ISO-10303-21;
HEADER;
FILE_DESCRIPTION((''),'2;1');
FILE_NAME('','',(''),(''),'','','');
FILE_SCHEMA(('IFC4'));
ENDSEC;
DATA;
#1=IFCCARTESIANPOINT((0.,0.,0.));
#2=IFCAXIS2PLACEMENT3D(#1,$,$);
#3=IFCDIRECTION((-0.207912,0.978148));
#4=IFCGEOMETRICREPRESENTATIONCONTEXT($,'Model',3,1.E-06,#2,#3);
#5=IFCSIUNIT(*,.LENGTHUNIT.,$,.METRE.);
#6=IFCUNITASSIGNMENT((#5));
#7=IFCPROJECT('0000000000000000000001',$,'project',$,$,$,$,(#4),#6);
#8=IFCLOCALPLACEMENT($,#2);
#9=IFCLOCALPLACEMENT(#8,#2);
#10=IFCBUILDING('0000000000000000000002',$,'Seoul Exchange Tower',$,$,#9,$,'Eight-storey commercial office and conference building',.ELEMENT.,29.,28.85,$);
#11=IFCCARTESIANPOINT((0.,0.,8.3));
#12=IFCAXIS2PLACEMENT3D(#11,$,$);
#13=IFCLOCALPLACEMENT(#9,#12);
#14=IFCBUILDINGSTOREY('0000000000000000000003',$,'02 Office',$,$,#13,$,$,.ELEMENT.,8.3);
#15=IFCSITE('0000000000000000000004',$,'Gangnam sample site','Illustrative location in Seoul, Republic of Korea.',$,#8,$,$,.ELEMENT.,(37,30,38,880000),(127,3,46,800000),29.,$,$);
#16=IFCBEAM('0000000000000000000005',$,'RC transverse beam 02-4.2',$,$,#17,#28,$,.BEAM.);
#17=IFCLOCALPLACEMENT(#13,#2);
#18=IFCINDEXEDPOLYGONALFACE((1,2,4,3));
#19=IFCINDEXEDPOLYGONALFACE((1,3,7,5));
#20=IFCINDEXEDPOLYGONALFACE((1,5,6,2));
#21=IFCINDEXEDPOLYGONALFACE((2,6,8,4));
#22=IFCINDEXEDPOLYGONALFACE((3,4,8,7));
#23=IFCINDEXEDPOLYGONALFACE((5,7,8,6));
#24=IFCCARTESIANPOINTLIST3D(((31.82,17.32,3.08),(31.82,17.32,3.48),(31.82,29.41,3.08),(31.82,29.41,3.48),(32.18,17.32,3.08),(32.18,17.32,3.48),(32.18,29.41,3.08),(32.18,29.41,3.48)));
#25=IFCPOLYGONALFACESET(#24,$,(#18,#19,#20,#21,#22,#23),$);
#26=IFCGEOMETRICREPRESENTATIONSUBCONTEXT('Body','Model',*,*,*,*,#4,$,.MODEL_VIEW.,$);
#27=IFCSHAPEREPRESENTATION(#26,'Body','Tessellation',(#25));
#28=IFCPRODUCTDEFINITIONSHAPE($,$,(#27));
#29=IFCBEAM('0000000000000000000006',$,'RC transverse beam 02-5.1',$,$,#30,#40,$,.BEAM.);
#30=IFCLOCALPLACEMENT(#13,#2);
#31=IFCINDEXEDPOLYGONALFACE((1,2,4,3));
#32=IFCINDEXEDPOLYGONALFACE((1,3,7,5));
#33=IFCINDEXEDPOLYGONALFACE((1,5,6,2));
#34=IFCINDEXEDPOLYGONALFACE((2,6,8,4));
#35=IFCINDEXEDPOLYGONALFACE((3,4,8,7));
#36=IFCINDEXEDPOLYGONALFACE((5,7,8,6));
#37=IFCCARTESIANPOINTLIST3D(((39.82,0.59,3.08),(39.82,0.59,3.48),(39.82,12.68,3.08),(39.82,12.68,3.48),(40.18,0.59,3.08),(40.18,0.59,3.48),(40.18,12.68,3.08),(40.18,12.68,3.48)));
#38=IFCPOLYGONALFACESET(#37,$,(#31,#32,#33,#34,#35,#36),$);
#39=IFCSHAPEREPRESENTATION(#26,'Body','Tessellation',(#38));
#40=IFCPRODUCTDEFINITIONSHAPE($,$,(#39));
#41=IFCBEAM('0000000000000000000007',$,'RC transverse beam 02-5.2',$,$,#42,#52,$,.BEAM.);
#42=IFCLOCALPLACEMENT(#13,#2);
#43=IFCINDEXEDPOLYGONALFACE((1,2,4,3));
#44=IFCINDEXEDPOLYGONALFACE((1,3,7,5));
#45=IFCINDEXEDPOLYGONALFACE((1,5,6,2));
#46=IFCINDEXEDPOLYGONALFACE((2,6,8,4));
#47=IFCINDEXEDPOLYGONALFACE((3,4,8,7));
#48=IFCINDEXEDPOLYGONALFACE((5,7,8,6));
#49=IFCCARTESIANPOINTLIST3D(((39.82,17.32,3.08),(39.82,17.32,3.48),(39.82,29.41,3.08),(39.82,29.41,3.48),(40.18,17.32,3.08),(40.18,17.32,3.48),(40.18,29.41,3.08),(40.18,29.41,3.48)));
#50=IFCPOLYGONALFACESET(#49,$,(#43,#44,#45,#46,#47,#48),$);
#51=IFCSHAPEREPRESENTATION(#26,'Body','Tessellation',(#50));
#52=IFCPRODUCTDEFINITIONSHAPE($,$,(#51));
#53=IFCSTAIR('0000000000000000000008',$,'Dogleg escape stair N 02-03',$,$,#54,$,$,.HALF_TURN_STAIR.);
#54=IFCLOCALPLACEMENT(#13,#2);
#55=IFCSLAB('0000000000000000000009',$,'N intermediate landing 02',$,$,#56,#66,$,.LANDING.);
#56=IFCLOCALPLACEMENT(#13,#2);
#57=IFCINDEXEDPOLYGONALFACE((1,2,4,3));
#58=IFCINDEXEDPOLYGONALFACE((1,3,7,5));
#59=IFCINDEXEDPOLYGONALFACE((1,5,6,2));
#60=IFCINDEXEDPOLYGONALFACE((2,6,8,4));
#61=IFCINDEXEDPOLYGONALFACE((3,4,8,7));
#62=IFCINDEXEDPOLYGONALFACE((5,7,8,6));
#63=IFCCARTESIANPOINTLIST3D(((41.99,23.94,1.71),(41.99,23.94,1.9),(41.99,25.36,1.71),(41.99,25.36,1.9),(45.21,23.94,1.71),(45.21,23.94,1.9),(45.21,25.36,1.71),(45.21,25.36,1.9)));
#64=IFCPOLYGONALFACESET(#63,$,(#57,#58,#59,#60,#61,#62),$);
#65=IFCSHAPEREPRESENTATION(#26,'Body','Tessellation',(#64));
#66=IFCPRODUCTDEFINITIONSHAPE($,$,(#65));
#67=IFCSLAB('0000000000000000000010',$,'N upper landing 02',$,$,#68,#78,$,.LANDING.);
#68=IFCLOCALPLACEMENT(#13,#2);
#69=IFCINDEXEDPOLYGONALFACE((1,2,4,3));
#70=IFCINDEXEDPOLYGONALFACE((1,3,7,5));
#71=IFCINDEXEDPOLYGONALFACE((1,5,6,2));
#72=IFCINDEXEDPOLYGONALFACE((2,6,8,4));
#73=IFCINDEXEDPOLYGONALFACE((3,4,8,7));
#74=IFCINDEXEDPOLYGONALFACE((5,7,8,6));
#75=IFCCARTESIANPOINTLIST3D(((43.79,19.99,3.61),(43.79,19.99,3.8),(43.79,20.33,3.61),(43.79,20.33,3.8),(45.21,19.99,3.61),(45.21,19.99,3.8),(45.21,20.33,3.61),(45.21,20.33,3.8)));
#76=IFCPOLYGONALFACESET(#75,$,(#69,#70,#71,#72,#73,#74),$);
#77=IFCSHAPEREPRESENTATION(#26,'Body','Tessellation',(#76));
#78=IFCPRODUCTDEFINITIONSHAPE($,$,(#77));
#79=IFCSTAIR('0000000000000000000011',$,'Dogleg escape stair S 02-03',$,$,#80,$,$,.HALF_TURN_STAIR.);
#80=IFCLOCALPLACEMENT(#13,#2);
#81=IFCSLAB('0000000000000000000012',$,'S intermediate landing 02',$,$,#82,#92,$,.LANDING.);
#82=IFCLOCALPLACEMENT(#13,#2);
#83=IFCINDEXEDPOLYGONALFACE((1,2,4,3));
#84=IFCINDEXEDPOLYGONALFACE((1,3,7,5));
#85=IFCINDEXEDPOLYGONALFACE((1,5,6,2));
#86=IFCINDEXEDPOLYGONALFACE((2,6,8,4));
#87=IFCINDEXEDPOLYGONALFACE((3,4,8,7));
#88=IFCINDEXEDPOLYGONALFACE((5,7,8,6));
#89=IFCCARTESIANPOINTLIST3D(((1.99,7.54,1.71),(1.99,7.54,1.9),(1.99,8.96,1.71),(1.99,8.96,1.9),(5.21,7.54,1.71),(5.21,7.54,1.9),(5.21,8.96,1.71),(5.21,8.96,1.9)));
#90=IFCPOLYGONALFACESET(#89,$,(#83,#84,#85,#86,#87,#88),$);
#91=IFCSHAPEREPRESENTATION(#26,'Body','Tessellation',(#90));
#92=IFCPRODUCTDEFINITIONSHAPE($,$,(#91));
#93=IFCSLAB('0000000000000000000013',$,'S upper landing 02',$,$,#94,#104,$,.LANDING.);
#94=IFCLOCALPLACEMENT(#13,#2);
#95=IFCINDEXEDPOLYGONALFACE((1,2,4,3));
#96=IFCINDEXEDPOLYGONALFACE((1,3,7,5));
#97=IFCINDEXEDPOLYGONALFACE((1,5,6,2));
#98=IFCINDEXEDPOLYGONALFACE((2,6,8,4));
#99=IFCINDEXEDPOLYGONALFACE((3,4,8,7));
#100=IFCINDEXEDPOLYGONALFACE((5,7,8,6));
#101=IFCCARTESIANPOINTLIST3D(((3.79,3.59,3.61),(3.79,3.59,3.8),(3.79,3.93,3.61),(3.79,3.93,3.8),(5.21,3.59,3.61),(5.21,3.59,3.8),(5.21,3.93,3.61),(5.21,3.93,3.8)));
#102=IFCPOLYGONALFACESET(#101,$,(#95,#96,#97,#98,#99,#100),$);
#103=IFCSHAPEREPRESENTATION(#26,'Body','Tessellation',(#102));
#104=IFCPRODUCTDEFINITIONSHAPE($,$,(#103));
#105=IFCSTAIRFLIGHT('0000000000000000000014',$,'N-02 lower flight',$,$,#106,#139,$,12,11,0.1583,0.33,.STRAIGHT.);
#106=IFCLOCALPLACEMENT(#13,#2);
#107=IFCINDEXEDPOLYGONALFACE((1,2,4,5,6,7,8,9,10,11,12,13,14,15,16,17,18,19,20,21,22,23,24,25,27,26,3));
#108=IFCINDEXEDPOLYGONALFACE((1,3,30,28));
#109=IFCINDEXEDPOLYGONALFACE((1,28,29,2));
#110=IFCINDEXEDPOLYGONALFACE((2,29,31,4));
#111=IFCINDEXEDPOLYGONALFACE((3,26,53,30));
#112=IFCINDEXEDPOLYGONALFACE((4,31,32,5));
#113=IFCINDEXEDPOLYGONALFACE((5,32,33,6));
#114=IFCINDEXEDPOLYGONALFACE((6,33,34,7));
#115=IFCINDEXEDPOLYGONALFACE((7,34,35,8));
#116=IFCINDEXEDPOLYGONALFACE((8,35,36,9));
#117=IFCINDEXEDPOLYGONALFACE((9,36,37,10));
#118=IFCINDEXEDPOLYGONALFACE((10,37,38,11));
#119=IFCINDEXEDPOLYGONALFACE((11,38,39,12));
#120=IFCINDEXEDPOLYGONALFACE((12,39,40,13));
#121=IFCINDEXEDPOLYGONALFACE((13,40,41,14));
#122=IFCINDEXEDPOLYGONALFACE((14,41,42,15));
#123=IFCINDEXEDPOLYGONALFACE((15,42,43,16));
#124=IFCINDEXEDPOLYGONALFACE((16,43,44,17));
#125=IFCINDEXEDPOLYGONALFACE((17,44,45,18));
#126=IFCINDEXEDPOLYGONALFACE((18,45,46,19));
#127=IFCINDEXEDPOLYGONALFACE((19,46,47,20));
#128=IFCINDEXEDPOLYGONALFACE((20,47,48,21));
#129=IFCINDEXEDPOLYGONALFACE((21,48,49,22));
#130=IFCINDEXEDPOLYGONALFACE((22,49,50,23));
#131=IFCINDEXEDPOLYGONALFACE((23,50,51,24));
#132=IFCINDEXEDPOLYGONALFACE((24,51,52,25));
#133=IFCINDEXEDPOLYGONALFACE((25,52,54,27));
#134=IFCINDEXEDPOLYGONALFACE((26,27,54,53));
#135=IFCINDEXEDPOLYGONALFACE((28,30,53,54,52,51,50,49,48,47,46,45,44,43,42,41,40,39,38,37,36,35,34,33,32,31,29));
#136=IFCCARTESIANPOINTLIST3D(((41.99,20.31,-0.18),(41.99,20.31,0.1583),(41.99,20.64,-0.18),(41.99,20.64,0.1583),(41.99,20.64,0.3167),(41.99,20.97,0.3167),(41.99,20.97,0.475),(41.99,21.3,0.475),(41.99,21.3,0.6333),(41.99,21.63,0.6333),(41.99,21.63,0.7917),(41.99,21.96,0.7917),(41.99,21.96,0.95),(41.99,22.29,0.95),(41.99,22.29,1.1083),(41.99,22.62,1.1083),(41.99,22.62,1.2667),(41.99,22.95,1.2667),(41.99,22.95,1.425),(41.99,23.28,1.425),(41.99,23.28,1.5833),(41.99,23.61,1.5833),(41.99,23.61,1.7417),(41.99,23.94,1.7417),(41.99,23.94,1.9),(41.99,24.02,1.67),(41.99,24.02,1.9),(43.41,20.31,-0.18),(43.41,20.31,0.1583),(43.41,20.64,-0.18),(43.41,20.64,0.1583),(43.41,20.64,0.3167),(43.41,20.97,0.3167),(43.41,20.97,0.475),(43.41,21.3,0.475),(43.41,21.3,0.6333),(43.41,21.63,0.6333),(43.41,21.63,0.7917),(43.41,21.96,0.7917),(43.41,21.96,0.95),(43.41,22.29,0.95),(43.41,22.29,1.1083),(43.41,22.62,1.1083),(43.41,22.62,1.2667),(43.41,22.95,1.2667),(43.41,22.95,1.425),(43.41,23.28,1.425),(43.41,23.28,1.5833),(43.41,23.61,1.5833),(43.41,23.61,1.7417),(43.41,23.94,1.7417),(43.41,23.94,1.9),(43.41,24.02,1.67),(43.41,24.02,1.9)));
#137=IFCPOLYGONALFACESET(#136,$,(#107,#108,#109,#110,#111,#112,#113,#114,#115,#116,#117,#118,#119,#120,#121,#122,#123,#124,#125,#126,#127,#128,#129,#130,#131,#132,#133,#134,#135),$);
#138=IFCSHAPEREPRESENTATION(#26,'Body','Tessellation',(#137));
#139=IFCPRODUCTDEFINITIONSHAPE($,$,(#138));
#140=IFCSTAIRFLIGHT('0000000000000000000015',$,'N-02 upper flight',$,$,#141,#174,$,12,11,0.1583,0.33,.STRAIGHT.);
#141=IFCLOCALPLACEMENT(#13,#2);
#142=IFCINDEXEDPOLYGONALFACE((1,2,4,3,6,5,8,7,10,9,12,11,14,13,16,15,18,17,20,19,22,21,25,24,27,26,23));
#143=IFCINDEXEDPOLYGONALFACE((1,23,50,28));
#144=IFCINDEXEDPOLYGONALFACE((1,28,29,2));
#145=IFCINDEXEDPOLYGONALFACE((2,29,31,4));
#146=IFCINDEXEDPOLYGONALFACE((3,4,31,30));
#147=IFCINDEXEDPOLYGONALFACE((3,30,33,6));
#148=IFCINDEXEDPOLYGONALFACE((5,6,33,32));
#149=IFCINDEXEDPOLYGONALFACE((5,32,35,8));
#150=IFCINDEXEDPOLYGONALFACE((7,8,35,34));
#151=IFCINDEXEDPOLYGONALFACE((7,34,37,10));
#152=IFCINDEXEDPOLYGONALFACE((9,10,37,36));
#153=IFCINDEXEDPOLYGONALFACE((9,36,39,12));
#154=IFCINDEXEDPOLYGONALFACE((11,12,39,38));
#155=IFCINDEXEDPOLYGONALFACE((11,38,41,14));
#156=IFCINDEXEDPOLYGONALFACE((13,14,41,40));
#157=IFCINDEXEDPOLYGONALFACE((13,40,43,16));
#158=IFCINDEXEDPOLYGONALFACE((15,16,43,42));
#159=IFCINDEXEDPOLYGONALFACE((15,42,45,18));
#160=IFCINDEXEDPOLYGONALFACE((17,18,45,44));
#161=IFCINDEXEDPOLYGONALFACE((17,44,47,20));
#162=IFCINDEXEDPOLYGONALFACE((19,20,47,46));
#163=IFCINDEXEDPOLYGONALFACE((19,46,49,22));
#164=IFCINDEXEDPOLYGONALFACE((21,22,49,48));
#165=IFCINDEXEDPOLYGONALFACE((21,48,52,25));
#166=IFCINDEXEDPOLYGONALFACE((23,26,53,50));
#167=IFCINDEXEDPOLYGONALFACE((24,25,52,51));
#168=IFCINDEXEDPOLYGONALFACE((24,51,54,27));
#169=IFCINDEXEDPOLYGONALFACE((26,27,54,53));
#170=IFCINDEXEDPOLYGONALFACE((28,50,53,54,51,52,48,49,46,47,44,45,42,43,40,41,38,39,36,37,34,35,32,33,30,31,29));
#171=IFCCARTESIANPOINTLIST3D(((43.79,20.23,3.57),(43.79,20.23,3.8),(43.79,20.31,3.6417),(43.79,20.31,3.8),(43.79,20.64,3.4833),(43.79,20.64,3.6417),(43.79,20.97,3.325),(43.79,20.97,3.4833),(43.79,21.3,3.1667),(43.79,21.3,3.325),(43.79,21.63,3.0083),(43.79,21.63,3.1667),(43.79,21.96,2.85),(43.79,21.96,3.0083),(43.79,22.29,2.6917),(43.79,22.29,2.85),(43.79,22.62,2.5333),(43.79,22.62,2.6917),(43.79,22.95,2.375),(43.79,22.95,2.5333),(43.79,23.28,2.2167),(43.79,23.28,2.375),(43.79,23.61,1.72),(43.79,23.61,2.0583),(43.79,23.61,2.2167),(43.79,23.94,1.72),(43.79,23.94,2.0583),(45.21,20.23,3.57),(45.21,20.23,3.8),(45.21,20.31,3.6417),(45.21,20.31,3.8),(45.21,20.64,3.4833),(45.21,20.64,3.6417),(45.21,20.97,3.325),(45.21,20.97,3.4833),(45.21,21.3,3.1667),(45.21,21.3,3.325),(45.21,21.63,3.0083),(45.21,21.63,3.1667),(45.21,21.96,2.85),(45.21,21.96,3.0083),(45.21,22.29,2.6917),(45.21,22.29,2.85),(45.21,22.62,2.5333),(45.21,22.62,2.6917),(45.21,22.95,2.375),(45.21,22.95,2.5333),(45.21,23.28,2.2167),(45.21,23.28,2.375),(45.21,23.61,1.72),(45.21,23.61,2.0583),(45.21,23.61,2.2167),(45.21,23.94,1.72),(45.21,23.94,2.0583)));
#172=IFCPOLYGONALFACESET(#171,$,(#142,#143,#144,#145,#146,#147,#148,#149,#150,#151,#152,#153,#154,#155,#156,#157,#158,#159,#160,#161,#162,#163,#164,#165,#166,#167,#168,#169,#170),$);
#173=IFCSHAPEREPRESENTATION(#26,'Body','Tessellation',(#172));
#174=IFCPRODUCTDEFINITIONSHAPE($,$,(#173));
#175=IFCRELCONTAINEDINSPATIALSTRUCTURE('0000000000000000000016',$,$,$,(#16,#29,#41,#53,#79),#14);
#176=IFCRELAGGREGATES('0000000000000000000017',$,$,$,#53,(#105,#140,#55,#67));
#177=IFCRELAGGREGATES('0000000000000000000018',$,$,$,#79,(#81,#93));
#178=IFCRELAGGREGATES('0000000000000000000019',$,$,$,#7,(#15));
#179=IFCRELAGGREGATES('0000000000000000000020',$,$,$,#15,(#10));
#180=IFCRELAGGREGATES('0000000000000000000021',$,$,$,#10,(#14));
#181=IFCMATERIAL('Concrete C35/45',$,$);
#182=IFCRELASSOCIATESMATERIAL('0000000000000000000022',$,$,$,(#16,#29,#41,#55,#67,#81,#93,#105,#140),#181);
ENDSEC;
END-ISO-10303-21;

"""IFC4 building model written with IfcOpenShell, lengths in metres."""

from ifc_helpers import new_model, si_unit, direction, frame, frame_2d, origin, place, context, subcontext, project, spatial, polyline, rectangle, outline, extrude, material, element, aggregate, save


model = new_model("IFC4")

# Units and contexts
model_context = context("Model", 3, precision=1e-06, world=origin(), true_north=direction((-0.207912, 0.978148)))
body_context = subcontext(model_context, "Body", "Model", "MODEL_VIEW")
ifc_project = project(units=[si_unit("LENGTHUNIT", "METRE")], contexts=[model_context])

# Site, building, storey
site_placement = place(None, origin())
site = spatial("IfcSite", under=ifc_project, at=site_placement, Name="Gangnam sample site", Description="Illustrative location in Seoul, Republic of Korea.", CompositionType="ELEMENT", RefLatitude=(37, 30, 38, 880000), RefLongitude=(127, 3, 46, 800000), RefElevation=29.0)
building_placement = place(site_placement, origin())
building = spatial("IfcBuilding", under=site, at=building_placement, Name="Seoul Exchange Tower", LongName="Eight-storey commercial office and conference building", CompositionType="ELEMENT", ElevationOfRefHeight=29.0, ElevationOfTerrain=28.85)
storey_placement = place(building_placement, frame((0.0, 0.0, 8.3)))
storey = spatial("IfcBuildingStorey", under=building, at=storey_placement, Name="02 Office", CompositionType="ELEMENT", Elevation=8.3)

# Beams
ifc_material_1 = material(Name="Concrete C35/45")
placement_1 = place(storey_placement, origin())
element("IfcBeam", 1, at=placement_1, inside=storey, material=ifc_material_1, Name="RC transverse beam 02-4.2", PredefinedType="BEAM", context=body_context, shape_type="SweptSolid", body=[
    extrude(rectangle(XDim=0.36, YDim=12.09, at=frame_2d((0.18, 6.045))), frame((31.82, 17.32, 3.08)), (0.0, 0.0, 1.0), 0.4),
])
element("IfcBeam", 2, at=placement_1, inside=storey, material=ifc_material_1, Name="RC transverse beam 02-5.1", PredefinedType="BEAM", context=body_context, shape_type="SweptSolid", body=[
    extrude(rectangle(XDim=0.36, YDim=12.09, at=frame_2d((0.18, 6.045))), frame((39.82, 0.59, 3.08)), (0.0, 0.0, 1.0), 0.4),
])
element("IfcBeam", 3, at=placement_1, inside=storey, material=ifc_material_1, Name="RC transverse beam 02-5.2", PredefinedType="BEAM", context=body_context, shape_type="SweptSolid", body=[
    extrude(rectangle(XDim=0.36, YDim=12.09, at=frame_2d((0.18, 6.045))), frame((39.82, 17.32, 3.08)), (0.0, 0.0, 1.0), 0.4),
])

# Stairs, slabs
stair_1 = element("IfcStair", 4, at=placement_1, inside=storey, Name="Dogleg escape stair N 02-03", PredefinedType="HALF_TURN_STAIR")
placement_2 = place(placement_1, origin())
slab_1 = element("IfcSlab", 5, at=placement_2, material=ifc_material_1, Name="N intermediate landing 02", PredefinedType="LANDING", context=body_context, shape_type="SweptSolid", body=[
    extrude(rectangle(XDim=3.22, YDim=1.42, at=frame_2d((1.61, 0.71))), frame((41.99, 23.94, 1.71)), (0.0, 0.0, 1.0), 0.19),
])
slab_2 = element("IfcSlab", 6, at=placement_2, material=ifc_material_1, Name="N upper landing 02", PredefinedType="LANDING", context=body_context, shape_type="SweptSolid", body=[
    extrude(rectangle(XDim=1.42, YDim=0.34, at=frame_2d((0.71, 0.17))), frame((43.79, 19.99, 3.61)), (0.0, 0.0, 1.0), 0.19),
])
stair_2 = element("IfcStair", 7, at=placement_1, inside=storey, Name="Dogleg escape stair S 02-03", PredefinedType="HALF_TURN_STAIR")
slab_3 = element("IfcSlab", 8, at=placement_2, material=ifc_material_1, Name="S intermediate landing 02", PredefinedType="LANDING", context=body_context, shape_type="SweptSolid", body=[
    extrude(rectangle(XDim=3.22, YDim=1.42, at=frame_2d((1.61, 0.71))), frame((1.99, 7.54, 1.71)), (0.0, 0.0, 1.0), 0.19),
])
slab_4 = element("IfcSlab", 9, at=placement_2, material=ifc_material_1, Name="S upper landing 02", PredefinedType="LANDING", context=body_context, shape_type="SweptSolid", body=[
    extrude(rectangle(XDim=1.42, YDim=0.34, at=frame_2d((0.71, 0.17))), frame((3.79, 3.59, 3.61)), (0.0, 0.0, 1.0), 0.19),
])

# Stair flights
stair_flight_1 = element("IfcStairFlight", 10, at=placement_2, material=ifc_material_1, Name="N-02 lower flight", NumberOfRisers=12, NumberOfTreads=11, PredefinedType="STRAIGHT", RiserHeight=0.1583, TreadLength=0.33, context=body_context, shape_type="SweptSolid", body=[
    extrude(outline(polyline([(0.0, -0.18), (0.0, 0.1583), (0.33, 0.1583), (0.33, 0.3167), (0.66, 0.3167), (0.66, 0.475), (0.99, 0.475), (0.99, 0.6333), (1.32, 0.6333), (1.32, 0.7917), (1.65, 0.7917), (1.65, 0.95), (1.98, 0.95), (1.98, 1.1083), (2.31, 1.1083), (2.31, 1.2667), (2.64, 1.2667), (2.64, 1.425), (2.97, 1.425), (2.97, 1.5833), (3.3, 1.5833), (3.3, 1.7417), (3.63, 1.7417), (3.63, 1.9), (3.71, 1.9), (3.71, 1.67), (0.33, -0.18), (0.0, -0.18)])), frame((41.99, 20.31, 0.0), z_axis=(1.0, 0.0, 0.0), x_axis=(0.0, 1.0, 0.0)), (0.0, 0.0, 1.0), 1.42),
])
stair_flight_2 = element("IfcStairFlight", 11, at=placement_2, material=ifc_material_1, Name="N-02 upper flight", NumberOfRisers=12, NumberOfTreads=11, PredefinedType="STRAIGHT", RiserHeight=0.1583, TreadLength=0.33, context=body_context, shape_type="SweptSolid", body=[
    extrude(outline(polyline([(0.0, -0.18), (0.0, 0.1583), (0.33, 0.1583), (0.33, 0.3167), (0.66, 0.3167), (0.66, 0.475), (0.99, 0.475), (0.99, 0.6333), (1.32, 0.6333), (1.32, 0.7917), (1.65, 0.7917), (1.65, 0.95), (1.98, 0.95), (1.98, 1.1083), (2.31, 1.1083), (2.31, 1.2667), (2.64, 1.2667), (2.64, 1.425), (2.97, 1.425), (2.97, 1.5833), (3.3, 1.5833), (3.3, 1.7417), (3.63, 1.7417), (3.63, 1.9), (3.71, 1.9), (3.71, 1.67), (0.33, -0.18), (0.0, -0.18)])), frame((45.21, 23.94, 1.9), z_axis=(-1.0, 0.0, 0.0), x_axis=(0.0, -1.0, 0.0)), (0.0, 0.0, 1.0), 1.42),
])

aggregate(stair_1, [stair_flight_1, stair_flight_2, slab_1, slab_2])
aggregate(stair_2, [slab_3, slab_4])

save(model, "model.ifc")
